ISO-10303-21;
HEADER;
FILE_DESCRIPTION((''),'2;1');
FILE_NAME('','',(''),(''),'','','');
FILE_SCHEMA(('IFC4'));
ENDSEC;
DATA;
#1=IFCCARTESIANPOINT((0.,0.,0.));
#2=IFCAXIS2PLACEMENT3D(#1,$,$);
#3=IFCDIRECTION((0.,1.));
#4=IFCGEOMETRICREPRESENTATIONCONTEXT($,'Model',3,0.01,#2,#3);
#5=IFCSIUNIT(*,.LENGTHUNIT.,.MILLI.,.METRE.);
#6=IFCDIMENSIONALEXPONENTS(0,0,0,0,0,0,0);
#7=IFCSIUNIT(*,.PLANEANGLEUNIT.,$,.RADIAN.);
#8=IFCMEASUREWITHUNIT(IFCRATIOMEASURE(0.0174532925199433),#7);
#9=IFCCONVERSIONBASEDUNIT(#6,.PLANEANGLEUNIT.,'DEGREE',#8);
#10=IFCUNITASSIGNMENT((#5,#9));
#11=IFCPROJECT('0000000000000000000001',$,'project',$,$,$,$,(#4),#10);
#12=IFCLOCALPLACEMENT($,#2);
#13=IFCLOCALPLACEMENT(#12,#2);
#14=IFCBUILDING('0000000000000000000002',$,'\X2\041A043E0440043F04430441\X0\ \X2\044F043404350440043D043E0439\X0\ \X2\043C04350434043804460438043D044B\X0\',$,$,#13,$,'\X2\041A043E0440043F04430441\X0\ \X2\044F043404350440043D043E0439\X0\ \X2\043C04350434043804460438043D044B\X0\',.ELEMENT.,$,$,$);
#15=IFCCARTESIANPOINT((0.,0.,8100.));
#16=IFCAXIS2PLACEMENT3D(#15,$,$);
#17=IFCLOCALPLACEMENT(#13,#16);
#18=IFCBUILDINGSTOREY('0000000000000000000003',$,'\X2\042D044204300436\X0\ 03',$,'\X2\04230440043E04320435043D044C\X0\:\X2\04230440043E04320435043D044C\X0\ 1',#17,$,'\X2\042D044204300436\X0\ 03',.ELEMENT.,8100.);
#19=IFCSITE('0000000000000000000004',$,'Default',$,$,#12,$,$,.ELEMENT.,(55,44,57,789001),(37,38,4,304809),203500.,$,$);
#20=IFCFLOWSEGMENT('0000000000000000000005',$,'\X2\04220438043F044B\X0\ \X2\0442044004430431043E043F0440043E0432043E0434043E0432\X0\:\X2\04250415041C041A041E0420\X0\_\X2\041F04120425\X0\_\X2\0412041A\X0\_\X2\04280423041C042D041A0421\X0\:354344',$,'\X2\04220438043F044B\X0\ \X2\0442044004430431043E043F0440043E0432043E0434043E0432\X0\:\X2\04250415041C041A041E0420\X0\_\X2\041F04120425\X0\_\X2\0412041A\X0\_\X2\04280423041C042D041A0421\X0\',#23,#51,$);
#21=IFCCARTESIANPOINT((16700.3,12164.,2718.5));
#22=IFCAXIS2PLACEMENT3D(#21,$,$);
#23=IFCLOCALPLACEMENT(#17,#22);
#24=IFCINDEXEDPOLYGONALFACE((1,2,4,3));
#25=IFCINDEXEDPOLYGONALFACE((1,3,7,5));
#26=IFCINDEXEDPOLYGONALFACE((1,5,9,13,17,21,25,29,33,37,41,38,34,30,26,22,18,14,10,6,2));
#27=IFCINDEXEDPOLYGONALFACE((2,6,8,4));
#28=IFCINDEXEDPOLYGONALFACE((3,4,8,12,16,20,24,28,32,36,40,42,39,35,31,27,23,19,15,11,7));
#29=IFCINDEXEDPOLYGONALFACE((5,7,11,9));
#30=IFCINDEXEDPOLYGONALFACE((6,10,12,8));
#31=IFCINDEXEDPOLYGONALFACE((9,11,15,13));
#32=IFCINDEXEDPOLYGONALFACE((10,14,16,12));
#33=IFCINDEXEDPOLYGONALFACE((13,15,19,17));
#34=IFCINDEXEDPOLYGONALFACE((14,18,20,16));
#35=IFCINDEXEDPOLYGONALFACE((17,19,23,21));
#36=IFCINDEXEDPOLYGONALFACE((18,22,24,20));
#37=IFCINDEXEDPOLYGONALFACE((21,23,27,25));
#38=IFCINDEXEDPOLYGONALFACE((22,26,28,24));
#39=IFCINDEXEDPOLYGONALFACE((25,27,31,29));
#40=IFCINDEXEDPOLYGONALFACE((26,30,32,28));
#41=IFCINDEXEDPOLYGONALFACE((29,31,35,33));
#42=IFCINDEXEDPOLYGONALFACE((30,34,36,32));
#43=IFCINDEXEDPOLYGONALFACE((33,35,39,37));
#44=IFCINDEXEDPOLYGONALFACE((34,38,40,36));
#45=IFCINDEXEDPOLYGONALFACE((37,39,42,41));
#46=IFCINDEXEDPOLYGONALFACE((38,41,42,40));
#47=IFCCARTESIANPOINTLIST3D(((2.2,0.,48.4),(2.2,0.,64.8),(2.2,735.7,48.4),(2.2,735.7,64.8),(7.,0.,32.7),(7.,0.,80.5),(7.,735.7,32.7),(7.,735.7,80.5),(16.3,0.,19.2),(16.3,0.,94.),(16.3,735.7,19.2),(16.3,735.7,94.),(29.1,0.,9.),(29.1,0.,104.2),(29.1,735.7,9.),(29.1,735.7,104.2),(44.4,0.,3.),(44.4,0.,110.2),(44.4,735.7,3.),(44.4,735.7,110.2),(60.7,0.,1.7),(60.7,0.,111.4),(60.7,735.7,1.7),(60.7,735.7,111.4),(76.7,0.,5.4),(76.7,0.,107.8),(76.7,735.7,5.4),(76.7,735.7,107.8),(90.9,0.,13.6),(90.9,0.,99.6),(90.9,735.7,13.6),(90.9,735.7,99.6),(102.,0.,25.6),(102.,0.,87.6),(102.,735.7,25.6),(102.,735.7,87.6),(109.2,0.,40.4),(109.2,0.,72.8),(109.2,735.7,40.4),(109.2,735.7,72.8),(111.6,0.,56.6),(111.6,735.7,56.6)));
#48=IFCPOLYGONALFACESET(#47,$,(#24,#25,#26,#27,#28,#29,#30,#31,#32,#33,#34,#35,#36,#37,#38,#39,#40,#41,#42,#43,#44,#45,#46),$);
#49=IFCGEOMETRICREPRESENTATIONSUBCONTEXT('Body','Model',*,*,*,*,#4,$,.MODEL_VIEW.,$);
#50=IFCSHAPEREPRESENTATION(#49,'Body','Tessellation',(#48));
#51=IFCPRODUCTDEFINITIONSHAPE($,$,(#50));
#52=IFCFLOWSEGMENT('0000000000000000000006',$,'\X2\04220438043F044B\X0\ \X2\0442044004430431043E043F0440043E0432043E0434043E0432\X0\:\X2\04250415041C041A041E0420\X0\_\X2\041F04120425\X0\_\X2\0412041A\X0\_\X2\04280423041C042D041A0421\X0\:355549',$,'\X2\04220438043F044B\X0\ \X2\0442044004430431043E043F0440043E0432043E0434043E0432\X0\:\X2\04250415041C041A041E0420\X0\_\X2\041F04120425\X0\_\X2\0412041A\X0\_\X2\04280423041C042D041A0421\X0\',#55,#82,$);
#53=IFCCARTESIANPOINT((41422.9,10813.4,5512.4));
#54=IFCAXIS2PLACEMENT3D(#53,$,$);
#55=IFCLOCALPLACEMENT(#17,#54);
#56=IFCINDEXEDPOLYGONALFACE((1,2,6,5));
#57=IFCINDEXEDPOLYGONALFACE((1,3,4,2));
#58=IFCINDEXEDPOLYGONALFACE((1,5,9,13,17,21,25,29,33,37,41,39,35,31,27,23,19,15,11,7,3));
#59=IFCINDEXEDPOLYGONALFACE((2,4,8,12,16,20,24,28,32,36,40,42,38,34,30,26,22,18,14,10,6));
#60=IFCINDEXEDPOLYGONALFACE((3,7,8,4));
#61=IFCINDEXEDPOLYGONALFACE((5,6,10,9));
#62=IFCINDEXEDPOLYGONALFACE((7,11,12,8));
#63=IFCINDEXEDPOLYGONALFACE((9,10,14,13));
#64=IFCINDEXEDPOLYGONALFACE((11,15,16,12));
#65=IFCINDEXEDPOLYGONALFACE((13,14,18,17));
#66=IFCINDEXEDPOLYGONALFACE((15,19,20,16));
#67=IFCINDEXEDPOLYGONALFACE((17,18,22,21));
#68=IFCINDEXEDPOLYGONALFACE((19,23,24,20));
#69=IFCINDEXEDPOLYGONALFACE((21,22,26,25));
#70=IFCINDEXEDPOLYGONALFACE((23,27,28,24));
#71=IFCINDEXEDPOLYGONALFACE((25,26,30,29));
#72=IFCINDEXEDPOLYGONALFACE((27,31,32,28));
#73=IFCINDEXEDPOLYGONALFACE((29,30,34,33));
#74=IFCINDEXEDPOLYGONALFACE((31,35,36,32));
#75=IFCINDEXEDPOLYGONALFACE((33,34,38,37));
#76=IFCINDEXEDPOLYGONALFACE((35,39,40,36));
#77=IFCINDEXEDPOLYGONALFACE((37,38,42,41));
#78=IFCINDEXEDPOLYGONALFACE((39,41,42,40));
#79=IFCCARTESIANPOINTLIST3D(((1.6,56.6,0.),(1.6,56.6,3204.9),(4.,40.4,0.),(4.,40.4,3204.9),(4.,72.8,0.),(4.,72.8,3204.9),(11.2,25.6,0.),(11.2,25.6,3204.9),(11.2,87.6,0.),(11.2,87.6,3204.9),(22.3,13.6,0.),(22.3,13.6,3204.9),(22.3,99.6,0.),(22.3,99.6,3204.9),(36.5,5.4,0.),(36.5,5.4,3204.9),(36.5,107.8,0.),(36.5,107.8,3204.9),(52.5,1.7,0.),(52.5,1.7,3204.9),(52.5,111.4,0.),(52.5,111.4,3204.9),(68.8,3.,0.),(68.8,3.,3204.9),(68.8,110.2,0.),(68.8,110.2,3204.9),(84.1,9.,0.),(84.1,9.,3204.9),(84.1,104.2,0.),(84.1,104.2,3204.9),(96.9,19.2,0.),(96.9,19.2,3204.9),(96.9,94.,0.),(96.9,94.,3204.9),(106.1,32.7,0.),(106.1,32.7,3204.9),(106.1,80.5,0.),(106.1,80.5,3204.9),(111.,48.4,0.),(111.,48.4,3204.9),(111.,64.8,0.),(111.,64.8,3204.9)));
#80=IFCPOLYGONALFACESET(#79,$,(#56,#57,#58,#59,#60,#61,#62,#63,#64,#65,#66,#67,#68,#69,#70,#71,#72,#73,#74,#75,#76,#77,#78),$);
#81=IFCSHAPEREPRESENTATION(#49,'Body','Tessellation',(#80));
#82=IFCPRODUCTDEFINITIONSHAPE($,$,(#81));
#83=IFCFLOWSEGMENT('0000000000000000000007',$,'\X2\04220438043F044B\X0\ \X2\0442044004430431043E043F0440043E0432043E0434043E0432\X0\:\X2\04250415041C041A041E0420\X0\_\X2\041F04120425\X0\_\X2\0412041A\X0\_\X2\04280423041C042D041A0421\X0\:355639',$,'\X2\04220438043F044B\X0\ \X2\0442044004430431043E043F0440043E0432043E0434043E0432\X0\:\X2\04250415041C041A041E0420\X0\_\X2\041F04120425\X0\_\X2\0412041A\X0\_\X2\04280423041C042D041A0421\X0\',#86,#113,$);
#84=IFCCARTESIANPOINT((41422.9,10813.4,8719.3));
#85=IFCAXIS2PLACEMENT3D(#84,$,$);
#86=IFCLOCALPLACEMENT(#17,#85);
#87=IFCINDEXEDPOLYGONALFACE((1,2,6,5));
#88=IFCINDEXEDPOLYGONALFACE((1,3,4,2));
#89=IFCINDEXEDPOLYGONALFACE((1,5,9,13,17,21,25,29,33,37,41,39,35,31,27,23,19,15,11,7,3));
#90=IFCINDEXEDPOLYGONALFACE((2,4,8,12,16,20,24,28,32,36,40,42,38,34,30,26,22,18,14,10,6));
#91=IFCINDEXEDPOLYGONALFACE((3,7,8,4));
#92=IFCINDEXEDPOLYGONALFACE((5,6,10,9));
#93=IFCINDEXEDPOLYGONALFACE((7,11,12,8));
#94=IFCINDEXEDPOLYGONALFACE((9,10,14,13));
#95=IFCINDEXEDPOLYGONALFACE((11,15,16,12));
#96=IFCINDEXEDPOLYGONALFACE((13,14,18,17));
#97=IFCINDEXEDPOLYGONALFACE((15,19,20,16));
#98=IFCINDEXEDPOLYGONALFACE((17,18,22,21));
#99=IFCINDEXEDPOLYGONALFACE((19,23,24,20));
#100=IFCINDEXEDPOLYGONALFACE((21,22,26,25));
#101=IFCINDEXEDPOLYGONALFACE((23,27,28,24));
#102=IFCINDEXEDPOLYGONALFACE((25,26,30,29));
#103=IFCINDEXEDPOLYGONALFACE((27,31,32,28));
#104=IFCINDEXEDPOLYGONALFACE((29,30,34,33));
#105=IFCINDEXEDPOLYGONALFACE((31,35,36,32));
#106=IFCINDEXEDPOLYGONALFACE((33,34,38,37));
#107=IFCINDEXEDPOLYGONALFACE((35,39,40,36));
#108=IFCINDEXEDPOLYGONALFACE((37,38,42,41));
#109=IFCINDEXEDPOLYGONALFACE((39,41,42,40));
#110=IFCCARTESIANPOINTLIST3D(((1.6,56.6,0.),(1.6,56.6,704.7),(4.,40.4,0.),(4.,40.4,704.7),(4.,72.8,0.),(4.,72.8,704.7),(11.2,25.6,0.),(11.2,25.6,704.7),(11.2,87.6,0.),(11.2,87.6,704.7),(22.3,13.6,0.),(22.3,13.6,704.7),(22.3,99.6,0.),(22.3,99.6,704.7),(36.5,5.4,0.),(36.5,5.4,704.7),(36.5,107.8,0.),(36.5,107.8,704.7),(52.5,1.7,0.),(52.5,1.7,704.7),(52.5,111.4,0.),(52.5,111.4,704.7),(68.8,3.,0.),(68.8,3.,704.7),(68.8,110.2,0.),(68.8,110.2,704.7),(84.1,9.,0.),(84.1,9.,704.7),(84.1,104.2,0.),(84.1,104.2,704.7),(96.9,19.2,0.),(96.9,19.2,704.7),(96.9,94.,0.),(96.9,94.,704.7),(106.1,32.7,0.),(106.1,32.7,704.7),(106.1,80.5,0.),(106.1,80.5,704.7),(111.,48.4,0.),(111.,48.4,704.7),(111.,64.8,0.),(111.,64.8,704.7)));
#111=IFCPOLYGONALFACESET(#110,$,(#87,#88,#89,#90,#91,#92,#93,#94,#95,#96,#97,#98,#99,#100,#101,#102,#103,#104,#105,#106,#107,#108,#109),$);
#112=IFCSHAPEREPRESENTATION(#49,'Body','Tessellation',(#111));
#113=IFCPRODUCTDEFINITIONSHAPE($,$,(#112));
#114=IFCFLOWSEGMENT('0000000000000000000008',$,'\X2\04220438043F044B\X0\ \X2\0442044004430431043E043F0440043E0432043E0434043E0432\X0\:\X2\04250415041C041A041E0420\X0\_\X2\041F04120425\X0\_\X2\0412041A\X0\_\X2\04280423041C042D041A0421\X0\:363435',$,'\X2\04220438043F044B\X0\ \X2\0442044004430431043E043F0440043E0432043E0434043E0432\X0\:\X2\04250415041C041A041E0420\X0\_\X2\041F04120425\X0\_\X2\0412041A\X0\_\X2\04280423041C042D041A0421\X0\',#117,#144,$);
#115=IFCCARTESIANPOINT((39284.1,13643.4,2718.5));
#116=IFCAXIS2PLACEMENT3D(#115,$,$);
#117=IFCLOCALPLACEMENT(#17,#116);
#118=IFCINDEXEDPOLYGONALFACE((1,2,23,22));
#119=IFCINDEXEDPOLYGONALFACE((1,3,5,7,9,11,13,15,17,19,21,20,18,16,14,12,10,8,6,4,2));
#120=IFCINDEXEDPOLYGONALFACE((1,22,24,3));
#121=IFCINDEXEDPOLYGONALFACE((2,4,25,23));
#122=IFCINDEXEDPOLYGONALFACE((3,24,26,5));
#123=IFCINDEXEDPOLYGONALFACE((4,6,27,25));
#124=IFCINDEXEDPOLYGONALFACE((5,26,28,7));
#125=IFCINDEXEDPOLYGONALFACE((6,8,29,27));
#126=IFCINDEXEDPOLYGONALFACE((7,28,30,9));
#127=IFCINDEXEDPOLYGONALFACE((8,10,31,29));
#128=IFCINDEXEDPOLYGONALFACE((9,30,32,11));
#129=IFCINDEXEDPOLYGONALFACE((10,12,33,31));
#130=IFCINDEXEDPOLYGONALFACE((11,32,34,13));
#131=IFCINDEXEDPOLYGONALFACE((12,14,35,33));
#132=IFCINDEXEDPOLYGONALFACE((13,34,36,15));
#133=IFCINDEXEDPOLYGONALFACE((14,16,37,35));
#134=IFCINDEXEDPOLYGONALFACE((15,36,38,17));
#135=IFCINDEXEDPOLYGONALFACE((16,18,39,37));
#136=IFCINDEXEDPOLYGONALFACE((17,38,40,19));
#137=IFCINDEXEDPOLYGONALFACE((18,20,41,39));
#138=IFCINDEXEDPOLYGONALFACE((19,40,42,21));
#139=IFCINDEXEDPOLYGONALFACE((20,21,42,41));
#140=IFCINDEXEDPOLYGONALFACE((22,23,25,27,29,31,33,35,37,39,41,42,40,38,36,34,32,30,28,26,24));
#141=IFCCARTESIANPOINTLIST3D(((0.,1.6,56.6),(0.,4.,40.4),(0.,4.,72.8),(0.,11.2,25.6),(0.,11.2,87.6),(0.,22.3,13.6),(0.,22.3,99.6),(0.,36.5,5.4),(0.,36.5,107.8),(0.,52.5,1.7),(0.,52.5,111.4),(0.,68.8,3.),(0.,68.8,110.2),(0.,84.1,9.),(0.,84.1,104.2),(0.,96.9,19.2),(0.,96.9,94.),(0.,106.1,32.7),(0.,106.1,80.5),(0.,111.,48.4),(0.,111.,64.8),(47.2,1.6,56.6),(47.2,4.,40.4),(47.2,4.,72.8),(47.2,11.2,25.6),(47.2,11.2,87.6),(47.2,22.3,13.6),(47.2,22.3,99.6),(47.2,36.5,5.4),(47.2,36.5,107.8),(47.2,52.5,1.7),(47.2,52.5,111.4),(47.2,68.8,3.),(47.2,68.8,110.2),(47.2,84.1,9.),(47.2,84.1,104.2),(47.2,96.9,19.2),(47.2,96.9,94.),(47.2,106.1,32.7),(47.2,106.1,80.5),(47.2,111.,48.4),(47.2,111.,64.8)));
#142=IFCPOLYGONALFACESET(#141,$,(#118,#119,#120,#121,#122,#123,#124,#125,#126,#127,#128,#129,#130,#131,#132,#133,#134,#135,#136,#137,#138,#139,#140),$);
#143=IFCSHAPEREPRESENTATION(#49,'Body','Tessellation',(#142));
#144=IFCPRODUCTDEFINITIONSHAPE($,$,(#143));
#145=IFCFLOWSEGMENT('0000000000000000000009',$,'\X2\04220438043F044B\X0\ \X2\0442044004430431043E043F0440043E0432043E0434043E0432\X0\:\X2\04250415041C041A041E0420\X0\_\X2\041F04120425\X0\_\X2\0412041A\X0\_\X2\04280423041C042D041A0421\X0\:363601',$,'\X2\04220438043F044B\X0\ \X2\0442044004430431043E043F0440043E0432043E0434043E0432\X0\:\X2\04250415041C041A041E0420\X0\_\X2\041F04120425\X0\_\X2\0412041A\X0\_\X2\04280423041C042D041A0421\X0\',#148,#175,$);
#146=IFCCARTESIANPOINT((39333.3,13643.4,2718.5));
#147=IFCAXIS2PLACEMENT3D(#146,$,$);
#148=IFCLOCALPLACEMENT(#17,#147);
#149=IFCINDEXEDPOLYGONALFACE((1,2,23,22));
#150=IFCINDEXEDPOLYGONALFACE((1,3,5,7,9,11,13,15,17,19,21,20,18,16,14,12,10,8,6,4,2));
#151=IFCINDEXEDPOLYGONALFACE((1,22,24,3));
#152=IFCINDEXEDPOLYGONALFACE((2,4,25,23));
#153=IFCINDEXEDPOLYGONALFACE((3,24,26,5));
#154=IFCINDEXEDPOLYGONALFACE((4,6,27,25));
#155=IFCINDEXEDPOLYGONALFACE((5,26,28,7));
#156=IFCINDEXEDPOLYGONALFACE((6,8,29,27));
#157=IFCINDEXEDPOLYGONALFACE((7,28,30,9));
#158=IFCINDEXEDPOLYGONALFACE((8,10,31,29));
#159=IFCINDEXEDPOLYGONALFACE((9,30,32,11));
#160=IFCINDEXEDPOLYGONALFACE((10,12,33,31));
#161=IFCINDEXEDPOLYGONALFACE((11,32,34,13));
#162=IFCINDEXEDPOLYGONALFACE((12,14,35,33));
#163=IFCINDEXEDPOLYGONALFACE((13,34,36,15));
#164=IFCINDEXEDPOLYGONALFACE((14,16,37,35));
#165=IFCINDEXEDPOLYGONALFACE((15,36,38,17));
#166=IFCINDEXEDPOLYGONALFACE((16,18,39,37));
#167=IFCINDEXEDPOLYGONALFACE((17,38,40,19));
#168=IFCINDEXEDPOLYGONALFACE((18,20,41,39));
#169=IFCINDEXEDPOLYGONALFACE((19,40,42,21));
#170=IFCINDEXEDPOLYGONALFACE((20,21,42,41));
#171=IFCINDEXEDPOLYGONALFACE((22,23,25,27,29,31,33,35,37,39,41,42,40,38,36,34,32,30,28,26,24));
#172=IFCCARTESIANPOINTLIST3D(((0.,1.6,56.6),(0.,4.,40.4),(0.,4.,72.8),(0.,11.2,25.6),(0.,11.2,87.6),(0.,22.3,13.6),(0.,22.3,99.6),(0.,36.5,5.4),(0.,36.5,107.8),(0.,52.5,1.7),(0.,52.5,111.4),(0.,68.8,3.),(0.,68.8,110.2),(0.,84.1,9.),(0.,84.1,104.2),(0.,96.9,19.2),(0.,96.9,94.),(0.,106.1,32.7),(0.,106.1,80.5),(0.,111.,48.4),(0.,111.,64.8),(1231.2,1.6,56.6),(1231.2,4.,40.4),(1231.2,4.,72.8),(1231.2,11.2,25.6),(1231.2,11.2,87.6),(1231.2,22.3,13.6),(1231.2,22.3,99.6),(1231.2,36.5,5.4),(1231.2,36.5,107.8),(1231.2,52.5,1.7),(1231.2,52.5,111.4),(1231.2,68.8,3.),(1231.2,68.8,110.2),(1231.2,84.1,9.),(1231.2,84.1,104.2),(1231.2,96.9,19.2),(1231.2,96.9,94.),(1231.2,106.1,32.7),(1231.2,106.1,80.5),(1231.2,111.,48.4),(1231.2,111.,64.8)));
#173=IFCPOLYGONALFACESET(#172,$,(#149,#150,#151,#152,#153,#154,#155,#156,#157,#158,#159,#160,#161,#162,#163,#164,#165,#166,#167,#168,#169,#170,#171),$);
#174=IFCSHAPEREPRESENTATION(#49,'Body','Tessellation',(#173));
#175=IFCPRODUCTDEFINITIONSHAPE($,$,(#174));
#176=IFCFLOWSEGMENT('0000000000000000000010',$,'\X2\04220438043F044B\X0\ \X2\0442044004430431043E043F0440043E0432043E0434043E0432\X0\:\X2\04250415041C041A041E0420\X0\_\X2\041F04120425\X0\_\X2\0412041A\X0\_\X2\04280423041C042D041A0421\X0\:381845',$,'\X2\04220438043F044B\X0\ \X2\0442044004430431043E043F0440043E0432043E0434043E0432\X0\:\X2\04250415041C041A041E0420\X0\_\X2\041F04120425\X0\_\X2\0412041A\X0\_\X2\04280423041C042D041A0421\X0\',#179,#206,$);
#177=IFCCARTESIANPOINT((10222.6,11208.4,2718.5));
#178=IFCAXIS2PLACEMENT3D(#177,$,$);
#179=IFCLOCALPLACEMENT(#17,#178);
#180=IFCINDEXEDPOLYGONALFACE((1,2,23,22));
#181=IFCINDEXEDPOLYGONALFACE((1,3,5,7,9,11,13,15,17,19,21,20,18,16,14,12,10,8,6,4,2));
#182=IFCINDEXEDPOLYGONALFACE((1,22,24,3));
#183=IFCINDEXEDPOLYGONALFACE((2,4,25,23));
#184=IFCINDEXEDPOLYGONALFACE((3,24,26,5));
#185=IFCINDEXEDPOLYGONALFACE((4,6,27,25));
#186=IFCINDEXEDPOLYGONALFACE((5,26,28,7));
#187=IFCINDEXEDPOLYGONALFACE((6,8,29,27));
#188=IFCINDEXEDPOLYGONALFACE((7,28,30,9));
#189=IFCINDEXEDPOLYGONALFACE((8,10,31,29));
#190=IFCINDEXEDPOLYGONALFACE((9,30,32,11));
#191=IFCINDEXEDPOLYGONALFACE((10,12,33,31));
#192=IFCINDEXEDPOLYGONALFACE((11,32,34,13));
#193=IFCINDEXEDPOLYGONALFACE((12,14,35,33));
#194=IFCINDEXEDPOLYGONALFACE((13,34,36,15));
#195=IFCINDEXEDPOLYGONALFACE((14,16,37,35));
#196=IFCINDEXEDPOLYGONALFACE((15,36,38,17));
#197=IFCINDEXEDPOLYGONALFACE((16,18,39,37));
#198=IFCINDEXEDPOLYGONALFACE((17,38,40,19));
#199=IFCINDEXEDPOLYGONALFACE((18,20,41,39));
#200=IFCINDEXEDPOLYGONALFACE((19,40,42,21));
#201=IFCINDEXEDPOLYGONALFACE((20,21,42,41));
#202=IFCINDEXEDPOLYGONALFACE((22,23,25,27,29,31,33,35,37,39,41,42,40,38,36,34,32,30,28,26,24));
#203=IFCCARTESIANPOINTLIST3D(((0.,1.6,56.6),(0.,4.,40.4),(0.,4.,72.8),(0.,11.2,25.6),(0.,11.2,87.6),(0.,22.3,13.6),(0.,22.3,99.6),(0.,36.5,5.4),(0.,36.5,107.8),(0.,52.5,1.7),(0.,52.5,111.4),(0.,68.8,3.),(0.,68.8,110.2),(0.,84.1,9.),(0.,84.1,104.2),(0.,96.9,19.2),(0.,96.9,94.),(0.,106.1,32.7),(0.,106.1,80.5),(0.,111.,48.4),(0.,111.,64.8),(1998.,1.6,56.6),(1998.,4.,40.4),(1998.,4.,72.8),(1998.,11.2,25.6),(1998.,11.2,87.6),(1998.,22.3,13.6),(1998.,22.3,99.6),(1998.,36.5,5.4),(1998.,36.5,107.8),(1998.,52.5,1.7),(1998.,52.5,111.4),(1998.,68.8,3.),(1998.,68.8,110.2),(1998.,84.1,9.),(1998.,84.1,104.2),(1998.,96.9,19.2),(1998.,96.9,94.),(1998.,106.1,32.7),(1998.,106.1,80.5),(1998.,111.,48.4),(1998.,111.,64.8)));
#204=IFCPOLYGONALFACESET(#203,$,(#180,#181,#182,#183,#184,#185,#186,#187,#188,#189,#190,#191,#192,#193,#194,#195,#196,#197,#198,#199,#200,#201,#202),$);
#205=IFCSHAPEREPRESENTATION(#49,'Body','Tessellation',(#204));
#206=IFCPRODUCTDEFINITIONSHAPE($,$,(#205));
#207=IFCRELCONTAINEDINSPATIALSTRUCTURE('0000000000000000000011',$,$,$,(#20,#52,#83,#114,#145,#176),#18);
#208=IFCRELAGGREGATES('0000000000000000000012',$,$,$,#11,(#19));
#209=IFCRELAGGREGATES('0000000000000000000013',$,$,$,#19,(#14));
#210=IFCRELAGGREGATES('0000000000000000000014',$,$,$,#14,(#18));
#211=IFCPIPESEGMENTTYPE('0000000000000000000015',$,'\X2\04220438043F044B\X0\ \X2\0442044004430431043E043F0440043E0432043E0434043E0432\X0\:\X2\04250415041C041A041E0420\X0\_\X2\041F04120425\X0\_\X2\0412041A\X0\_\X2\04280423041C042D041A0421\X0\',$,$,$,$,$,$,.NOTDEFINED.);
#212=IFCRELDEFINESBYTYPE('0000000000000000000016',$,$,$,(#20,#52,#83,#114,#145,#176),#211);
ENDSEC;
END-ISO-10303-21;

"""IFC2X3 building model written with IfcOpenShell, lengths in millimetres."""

from ifc_helpers import new_model, entity, si_unit, converted_unit, direction, frame, origin, origin_2d_with_axis, place, context, subcontext, project, spatial, circle, extrude, type_object, element, save


model = new_model("IFC2X3")

# Units and contexts
model_context = context("Model", 3, precision=0.01, world=origin(), true_north=direction((0.0, 1.0)))
body_context = subcontext(model_context, "Body", "Model", "MODEL_VIEW")
ifc_project = project(units=[si_unit("LENGTHUNIT", "METRE", prefix="MILLI"), converted_unit("PLANEANGLEUNIT", "DEGREE", entity("IfcRatioMeasure", 0.0174532925199433), si_unit("PLANEANGLEUNIT", "RADIAN"), dimensions=[0, 0, 0, 0, 0, 0, 0])], contexts=[model_context])

# Site, building, storey
site_placement = place(None, frame((0.0, 0.0, 0.0)))
site = spatial("IfcSite", under=ifc_project, at=site_placement, Name="Default", CompositionType="ELEMENT", RefLatitude=(55, 44, 57, 789001), RefLongitude=(37, 38, 4, 304809), RefElevation=203500.0)
building_placement = place(site_placement, origin())
building = spatial("IfcBuilding", under=site, at=building_placement, Name="Корпус ядерной медицины", LongName="Корпус ядерной медицины", CompositionType="ELEMENT")
storey_placement = place(building_placement, frame((0.0, 0.0, 8100.0)))
storey = spatial("IfcBuildingStorey", under=building, at=storey_placement, Name="Этаж 03", ObjectType="Уровень:Уровень 1", LongName="Этаж 03", CompositionType="ELEMENT", Elevation=8100.0)

# Flow segments
pipe_segment_type = type_object("IfcPipeSegmentType", Name="Типы трубопроводов:ХЕМКОР_ПВХ_ВК_ШУМЭКС", PredefinedType="NOTDEFINED")
flow_segment_1_placement = place(storey_placement, frame((16700.3, 12164.0, 2718.5)))
element("IfcFlowSegment", 1, at=flow_segment_1_placement, inside=storey, type_object=pipe_segment_type, Name="Типы трубопроводов:ХЕМКОР_ПВХ_ВК_ШУМЭКС:354344", ObjectType="Типы трубопроводов:ХЕМКОР_ПВХ_ВК_ШУМЭКС", context=body_context, shape_type="SweptSolid", body=[
    extrude(circle(Radius=55.0, at=origin_2d_with_axis()), frame((56.6, 0.0, 56.6), z_axis=(0.0, 1.0, 0.0), x_axis=(1.0, 0.0, 0.0)), (0.0, 0.0, 1.0), 735.7),
])
flow_segment_2_placement = place(storey_placement, frame((41422.9, 10813.4, 5512.4)))
element("IfcFlowSegment", 2, at=flow_segment_2_placement, inside=storey, type_object=pipe_segment_type, Name="Типы трубопроводов:ХЕМКОР_ПВХ_ВК_ШУМЭКС:355549", ObjectType="Типы трубопроводов:ХЕМКОР_ПВХ_ВК_ШУМЭКС", context=body_context, shape_type="SweptSolid", body=[
    extrude(circle(Radius=55.0, at=origin_2d_with_axis()), frame((56.6, 56.6, 0.0), z_axis=(0.0, 0.0, 1.0), x_axis=(-1.0, 0.0, 0.0)), (0.0, 0.0, 1.0), 3204.9),
])
flow_segment_3_placement = place(storey_placement, frame((41422.9, 10813.4, 8719.3)))
element("IfcFlowSegment", 3, at=flow_segment_3_placement, inside=storey, type_object=pipe_segment_type, Name="Типы трубопроводов:ХЕМКОР_ПВХ_ВК_ШУМЭКС:355639", ObjectType="Типы трубопроводов:ХЕМКОР_ПВХ_ВК_ШУМЭКС", context=body_context, shape_type="SweptSolid", body=[
    extrude(circle(Radius=55.0, at=origin_2d_with_axis()), frame((56.6, 56.6, 0.0), z_axis=(0.0, 0.0, 1.0), x_axis=(-1.0, 0.0, 0.0)), (0.0, 0.0, 1.0), 704.7),
])
flow_segment_4_placement = place(storey_placement, frame((39284.1, 13643.4, 2718.5)))
element("IfcFlowSegment", 4, at=flow_segment_4_placement, inside=storey, type_object=pipe_segment_type, Name="Типы трубопроводов:ХЕМКОР_ПВХ_ВК_ШУМЭКС:363435", ObjectType="Типы трубопроводов:ХЕМКОР_ПВХ_ВК_ШУМЭКС", context=body_context, shape_type="SweptSolid", body=[
    extrude(circle(Radius=55.0, at=origin_2d_with_axis()), frame((0.0, 56.6, 56.6), z_axis=(1.0, 0.0, 0.0), x_axis=(0.0, -1.0, 0.0)), (0.0, 0.0, 1.0), 47.2),
])
flow_segment_5_placement = place(storey_placement, frame((39333.3, 13643.4, 2718.5)))
element("IfcFlowSegment", 5, at=flow_segment_5_placement, inside=storey, type_object=pipe_segment_type, Name="Типы трубопроводов:ХЕМКОР_ПВХ_ВК_ШУМЭКС:363601", ObjectType="Типы трубопроводов:ХЕМКОР_ПВХ_ВК_ШУМЭКС", context=body_context, shape_type="SweptSolid", body=[
    extrude(circle(Radius=55.0, at=origin_2d_with_axis()), frame((0.0, 56.6, 56.6), z_axis=(1.0, 0.0, 0.0), x_axis=(0.0, -1.0, 0.0)), (0.0, 0.0, 1.0), 1231.2),
])
for number, where, name in (
    (6, (10222.6, 11208.4, 2718.5), "Типы трубопроводов:ХЕМКОР_ПВХ_ВК_ШУМЭКС:381845"),
):
    element("IfcFlowSegment", number, at=place(storey_placement, frame(where)), inside=storey, type_object=pipe_segment_type, Name=name, ObjectType="Типы трубопроводов:ХЕМКОР_ПВХ_ВК_ШУМЭКС", context=body_context, shape_type="SweptSolid", body=[
        extrude(circle(Radius=55.0, at=origin_2d_with_axis()), frame((0.0, 56.6, 56.6), z_axis=(1.0, 0.0, 0.0), x_axis=(0.0, -1.0, 0.0)), (0.0, 0.0, 1.0), 1998.0),
    ])

save(model, "model.ifc")
